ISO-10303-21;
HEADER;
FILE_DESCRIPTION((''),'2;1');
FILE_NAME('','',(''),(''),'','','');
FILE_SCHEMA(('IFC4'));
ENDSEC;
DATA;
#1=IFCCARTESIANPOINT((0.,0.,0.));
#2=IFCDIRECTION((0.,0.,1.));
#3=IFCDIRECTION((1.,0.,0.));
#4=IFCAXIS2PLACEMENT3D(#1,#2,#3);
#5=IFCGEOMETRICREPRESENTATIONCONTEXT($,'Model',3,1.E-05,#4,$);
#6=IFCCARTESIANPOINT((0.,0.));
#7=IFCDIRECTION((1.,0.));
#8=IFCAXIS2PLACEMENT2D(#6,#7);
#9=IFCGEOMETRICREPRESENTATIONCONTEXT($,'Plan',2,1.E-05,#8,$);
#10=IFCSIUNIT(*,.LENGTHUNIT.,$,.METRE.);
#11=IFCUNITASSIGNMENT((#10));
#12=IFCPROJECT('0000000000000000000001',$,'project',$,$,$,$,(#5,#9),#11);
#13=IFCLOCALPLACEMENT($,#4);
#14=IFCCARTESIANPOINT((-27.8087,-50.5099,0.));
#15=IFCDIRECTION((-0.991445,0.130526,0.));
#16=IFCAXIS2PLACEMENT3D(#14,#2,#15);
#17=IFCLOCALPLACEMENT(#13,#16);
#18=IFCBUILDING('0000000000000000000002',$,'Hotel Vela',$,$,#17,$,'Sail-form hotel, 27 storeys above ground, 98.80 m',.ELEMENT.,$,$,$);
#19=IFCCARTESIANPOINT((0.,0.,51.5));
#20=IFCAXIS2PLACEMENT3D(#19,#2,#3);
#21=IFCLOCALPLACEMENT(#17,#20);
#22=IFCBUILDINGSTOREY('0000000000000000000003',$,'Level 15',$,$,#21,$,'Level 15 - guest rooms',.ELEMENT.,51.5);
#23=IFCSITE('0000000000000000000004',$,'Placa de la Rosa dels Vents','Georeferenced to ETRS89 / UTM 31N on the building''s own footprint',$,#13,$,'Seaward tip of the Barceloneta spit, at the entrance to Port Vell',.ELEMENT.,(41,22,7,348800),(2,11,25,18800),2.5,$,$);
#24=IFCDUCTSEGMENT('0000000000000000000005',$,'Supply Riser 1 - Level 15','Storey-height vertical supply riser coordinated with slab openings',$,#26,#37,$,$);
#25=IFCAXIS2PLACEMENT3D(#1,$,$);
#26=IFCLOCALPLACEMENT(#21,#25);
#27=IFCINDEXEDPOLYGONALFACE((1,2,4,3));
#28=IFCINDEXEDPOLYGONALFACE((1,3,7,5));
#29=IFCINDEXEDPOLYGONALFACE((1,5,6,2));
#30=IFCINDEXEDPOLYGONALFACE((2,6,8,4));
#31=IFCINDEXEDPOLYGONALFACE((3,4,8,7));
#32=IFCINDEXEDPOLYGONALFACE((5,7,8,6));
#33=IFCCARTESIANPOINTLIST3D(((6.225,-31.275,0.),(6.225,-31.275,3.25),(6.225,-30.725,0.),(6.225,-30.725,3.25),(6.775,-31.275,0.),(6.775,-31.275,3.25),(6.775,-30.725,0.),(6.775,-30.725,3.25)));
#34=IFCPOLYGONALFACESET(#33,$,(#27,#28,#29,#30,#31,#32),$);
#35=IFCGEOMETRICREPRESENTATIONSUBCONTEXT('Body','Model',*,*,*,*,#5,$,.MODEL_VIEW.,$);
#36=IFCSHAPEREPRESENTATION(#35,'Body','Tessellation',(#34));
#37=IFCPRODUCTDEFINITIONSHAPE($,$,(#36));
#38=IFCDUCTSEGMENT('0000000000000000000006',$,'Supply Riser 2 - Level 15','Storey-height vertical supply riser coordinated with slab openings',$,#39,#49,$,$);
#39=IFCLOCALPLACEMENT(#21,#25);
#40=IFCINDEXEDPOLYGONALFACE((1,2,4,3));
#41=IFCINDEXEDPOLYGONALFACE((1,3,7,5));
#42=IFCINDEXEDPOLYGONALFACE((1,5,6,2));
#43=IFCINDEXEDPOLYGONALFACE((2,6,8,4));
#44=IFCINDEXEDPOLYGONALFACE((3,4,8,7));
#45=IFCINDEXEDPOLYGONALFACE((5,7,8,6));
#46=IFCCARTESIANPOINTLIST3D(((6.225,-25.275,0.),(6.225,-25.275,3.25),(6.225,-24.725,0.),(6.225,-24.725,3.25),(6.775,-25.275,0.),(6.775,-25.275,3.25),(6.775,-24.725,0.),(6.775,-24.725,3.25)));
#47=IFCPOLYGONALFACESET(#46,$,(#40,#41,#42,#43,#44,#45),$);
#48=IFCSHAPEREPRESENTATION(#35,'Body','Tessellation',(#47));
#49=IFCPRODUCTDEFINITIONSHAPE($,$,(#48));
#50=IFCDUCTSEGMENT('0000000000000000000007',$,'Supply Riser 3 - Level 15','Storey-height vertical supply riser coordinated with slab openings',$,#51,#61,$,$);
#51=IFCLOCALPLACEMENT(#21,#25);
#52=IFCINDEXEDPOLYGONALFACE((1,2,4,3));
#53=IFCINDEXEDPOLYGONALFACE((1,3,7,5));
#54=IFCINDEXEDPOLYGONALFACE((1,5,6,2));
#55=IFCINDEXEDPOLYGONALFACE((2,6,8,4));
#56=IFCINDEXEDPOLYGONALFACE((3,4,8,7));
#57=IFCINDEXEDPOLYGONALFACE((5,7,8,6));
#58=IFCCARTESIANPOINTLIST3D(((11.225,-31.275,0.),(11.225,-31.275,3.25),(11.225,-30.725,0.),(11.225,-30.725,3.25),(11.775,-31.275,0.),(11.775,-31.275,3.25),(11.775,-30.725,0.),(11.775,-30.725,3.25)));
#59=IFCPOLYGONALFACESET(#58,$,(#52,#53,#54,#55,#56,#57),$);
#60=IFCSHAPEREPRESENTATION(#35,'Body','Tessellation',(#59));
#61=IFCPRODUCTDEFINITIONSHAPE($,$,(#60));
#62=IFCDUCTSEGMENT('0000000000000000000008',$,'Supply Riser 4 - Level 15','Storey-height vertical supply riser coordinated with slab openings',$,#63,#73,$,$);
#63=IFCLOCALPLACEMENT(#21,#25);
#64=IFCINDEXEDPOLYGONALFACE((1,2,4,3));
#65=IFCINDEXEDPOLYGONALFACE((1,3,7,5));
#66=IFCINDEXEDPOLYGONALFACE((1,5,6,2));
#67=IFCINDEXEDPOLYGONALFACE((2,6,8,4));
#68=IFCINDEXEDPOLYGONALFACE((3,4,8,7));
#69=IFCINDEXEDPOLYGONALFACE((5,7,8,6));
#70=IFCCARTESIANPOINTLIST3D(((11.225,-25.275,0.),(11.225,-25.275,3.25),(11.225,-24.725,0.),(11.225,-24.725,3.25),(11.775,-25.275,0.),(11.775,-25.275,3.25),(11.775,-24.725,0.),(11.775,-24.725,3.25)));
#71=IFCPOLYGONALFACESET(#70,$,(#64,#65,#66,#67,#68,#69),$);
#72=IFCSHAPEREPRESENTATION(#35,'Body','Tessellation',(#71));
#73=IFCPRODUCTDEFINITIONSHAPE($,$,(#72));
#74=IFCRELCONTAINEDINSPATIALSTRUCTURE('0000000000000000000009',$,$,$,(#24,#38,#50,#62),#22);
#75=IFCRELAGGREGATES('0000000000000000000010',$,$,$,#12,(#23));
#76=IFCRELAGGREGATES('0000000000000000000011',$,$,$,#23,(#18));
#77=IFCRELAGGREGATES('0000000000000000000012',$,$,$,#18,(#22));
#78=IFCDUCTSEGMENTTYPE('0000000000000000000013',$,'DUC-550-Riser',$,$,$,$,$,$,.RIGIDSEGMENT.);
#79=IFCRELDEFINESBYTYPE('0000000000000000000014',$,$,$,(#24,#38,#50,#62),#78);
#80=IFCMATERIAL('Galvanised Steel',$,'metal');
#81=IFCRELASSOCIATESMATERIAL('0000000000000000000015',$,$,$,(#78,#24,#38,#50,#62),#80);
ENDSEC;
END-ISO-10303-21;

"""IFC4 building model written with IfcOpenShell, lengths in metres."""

from ifc_helpers import new_model, si_unit, frame, origin_with_axes, origin_2d_with_axis, place, context, subcontext, project, spatial, line, indexed_curve, outline, extrude, material, type_object, element, save


model = new_model("IFC4")

# Units and contexts
model_context = context("Model", 3, precision=1e-05, world=origin_with_axes())
plan_context = context("Plan", 2, precision=1e-05, world=origin_2d_with_axis())
body_context = subcontext(model_context, "Body", "Model", "MODEL_VIEW")
ifc_project = project(units=[si_unit("LENGTHUNIT", "METRE")], contexts=[model_context, plan_context])

# Site, building, storey
site_placement = place(None, origin_with_axes())
site = spatial("IfcSite", under=ifc_project, at=site_placement, Name="Placa de la Rosa dels Vents", Description="Georeferenced to ETRS89 / UTM 31N on the building's own footprint", LongName="Seaward tip of the Barceloneta spit, at the entrance to Port Vell", CompositionType="ELEMENT", RefLatitude=(41, 22, 7, 348800), RefLongitude=(2, 11, 25, 18800), RefElevation=2.5)
building_placement = place(site_placement, frame((-27.8087, -50.5099, 0.0), z_axis=(0.0, 0.0, 1.0), x_axis=(-0.991445, 0.130526, 0.0)))
building = spatial("IfcBuilding", under=site, at=building_placement, Name="Hotel Vela", LongName="Sail-form hotel, 27 storeys above ground, 98.80 m", CompositionType="ELEMENT")
storey_placement = place(building_placement, frame((0.0, 0.0, 51.5), z_axis=(0.0, 0.0, 1.0), x_axis=(1.0, 0.0, 0.0)))
storey = spatial("IfcBuildingStorey", under=building, at=storey_placement, Name="Level 15", LongName="Level 15 - guest rooms", CompositionType="ELEMENT", Elevation=51.5)

# Duct segments
ifc_material = material(Name="Galvanised Steel", Category="metal")
duct_segment_type = type_object("IfcDuctSegmentType", Name="DUC-550-Riser", PredefinedType="RIGIDSEGMENT", material=ifc_material)
for number, where, z_axis, x_axis, name in (
    (1, (6.225, -31.275, 0.0), (0.0, 0.0, 1.0), (1.0, 0.0, 0.0), "Supply Riser 1 - Level 15"),
    (2, (6.225, -25.275, 0.0), (0.0, 0.0, 1.0), (1.0, 0.0, 0.0), "Supply Riser 2 - Level 15"),
    (3, (11.225, -31.275, 0.0), (0.0, 0.0, 1.0), (1.0, 0.0, 0.0), "Supply Riser 3 - Level 15"),
    (4, (11.225, -25.275, 0.0), (0.0, 0.0, 1.0), (1.0, 0.0, 0.0), "Supply Riser 4 - Level 15"),
):
    element("IfcDuctSegment", number, at=place(storey_placement, frame(where, z_axis=z_axis, x_axis=x_axis)), inside=storey, type_object=duct_segment_type, material=ifc_material, Name=name, Description="Storey-height vertical supply riser coordinated with slab openings", context=body_context, shape_type="SweptSolid", body=[
        extrude(outline(indexed_curve([(0.0, 0.0), (0.55, 0.0), (0.55, 0.55), (0.0, 0.55)], segments=[line(1, 2, 3, 4, 1)])), origin_with_axes(), (0.0, 0.0, 1.0), 3.25),
    ])

save(model, "model.ifc")
